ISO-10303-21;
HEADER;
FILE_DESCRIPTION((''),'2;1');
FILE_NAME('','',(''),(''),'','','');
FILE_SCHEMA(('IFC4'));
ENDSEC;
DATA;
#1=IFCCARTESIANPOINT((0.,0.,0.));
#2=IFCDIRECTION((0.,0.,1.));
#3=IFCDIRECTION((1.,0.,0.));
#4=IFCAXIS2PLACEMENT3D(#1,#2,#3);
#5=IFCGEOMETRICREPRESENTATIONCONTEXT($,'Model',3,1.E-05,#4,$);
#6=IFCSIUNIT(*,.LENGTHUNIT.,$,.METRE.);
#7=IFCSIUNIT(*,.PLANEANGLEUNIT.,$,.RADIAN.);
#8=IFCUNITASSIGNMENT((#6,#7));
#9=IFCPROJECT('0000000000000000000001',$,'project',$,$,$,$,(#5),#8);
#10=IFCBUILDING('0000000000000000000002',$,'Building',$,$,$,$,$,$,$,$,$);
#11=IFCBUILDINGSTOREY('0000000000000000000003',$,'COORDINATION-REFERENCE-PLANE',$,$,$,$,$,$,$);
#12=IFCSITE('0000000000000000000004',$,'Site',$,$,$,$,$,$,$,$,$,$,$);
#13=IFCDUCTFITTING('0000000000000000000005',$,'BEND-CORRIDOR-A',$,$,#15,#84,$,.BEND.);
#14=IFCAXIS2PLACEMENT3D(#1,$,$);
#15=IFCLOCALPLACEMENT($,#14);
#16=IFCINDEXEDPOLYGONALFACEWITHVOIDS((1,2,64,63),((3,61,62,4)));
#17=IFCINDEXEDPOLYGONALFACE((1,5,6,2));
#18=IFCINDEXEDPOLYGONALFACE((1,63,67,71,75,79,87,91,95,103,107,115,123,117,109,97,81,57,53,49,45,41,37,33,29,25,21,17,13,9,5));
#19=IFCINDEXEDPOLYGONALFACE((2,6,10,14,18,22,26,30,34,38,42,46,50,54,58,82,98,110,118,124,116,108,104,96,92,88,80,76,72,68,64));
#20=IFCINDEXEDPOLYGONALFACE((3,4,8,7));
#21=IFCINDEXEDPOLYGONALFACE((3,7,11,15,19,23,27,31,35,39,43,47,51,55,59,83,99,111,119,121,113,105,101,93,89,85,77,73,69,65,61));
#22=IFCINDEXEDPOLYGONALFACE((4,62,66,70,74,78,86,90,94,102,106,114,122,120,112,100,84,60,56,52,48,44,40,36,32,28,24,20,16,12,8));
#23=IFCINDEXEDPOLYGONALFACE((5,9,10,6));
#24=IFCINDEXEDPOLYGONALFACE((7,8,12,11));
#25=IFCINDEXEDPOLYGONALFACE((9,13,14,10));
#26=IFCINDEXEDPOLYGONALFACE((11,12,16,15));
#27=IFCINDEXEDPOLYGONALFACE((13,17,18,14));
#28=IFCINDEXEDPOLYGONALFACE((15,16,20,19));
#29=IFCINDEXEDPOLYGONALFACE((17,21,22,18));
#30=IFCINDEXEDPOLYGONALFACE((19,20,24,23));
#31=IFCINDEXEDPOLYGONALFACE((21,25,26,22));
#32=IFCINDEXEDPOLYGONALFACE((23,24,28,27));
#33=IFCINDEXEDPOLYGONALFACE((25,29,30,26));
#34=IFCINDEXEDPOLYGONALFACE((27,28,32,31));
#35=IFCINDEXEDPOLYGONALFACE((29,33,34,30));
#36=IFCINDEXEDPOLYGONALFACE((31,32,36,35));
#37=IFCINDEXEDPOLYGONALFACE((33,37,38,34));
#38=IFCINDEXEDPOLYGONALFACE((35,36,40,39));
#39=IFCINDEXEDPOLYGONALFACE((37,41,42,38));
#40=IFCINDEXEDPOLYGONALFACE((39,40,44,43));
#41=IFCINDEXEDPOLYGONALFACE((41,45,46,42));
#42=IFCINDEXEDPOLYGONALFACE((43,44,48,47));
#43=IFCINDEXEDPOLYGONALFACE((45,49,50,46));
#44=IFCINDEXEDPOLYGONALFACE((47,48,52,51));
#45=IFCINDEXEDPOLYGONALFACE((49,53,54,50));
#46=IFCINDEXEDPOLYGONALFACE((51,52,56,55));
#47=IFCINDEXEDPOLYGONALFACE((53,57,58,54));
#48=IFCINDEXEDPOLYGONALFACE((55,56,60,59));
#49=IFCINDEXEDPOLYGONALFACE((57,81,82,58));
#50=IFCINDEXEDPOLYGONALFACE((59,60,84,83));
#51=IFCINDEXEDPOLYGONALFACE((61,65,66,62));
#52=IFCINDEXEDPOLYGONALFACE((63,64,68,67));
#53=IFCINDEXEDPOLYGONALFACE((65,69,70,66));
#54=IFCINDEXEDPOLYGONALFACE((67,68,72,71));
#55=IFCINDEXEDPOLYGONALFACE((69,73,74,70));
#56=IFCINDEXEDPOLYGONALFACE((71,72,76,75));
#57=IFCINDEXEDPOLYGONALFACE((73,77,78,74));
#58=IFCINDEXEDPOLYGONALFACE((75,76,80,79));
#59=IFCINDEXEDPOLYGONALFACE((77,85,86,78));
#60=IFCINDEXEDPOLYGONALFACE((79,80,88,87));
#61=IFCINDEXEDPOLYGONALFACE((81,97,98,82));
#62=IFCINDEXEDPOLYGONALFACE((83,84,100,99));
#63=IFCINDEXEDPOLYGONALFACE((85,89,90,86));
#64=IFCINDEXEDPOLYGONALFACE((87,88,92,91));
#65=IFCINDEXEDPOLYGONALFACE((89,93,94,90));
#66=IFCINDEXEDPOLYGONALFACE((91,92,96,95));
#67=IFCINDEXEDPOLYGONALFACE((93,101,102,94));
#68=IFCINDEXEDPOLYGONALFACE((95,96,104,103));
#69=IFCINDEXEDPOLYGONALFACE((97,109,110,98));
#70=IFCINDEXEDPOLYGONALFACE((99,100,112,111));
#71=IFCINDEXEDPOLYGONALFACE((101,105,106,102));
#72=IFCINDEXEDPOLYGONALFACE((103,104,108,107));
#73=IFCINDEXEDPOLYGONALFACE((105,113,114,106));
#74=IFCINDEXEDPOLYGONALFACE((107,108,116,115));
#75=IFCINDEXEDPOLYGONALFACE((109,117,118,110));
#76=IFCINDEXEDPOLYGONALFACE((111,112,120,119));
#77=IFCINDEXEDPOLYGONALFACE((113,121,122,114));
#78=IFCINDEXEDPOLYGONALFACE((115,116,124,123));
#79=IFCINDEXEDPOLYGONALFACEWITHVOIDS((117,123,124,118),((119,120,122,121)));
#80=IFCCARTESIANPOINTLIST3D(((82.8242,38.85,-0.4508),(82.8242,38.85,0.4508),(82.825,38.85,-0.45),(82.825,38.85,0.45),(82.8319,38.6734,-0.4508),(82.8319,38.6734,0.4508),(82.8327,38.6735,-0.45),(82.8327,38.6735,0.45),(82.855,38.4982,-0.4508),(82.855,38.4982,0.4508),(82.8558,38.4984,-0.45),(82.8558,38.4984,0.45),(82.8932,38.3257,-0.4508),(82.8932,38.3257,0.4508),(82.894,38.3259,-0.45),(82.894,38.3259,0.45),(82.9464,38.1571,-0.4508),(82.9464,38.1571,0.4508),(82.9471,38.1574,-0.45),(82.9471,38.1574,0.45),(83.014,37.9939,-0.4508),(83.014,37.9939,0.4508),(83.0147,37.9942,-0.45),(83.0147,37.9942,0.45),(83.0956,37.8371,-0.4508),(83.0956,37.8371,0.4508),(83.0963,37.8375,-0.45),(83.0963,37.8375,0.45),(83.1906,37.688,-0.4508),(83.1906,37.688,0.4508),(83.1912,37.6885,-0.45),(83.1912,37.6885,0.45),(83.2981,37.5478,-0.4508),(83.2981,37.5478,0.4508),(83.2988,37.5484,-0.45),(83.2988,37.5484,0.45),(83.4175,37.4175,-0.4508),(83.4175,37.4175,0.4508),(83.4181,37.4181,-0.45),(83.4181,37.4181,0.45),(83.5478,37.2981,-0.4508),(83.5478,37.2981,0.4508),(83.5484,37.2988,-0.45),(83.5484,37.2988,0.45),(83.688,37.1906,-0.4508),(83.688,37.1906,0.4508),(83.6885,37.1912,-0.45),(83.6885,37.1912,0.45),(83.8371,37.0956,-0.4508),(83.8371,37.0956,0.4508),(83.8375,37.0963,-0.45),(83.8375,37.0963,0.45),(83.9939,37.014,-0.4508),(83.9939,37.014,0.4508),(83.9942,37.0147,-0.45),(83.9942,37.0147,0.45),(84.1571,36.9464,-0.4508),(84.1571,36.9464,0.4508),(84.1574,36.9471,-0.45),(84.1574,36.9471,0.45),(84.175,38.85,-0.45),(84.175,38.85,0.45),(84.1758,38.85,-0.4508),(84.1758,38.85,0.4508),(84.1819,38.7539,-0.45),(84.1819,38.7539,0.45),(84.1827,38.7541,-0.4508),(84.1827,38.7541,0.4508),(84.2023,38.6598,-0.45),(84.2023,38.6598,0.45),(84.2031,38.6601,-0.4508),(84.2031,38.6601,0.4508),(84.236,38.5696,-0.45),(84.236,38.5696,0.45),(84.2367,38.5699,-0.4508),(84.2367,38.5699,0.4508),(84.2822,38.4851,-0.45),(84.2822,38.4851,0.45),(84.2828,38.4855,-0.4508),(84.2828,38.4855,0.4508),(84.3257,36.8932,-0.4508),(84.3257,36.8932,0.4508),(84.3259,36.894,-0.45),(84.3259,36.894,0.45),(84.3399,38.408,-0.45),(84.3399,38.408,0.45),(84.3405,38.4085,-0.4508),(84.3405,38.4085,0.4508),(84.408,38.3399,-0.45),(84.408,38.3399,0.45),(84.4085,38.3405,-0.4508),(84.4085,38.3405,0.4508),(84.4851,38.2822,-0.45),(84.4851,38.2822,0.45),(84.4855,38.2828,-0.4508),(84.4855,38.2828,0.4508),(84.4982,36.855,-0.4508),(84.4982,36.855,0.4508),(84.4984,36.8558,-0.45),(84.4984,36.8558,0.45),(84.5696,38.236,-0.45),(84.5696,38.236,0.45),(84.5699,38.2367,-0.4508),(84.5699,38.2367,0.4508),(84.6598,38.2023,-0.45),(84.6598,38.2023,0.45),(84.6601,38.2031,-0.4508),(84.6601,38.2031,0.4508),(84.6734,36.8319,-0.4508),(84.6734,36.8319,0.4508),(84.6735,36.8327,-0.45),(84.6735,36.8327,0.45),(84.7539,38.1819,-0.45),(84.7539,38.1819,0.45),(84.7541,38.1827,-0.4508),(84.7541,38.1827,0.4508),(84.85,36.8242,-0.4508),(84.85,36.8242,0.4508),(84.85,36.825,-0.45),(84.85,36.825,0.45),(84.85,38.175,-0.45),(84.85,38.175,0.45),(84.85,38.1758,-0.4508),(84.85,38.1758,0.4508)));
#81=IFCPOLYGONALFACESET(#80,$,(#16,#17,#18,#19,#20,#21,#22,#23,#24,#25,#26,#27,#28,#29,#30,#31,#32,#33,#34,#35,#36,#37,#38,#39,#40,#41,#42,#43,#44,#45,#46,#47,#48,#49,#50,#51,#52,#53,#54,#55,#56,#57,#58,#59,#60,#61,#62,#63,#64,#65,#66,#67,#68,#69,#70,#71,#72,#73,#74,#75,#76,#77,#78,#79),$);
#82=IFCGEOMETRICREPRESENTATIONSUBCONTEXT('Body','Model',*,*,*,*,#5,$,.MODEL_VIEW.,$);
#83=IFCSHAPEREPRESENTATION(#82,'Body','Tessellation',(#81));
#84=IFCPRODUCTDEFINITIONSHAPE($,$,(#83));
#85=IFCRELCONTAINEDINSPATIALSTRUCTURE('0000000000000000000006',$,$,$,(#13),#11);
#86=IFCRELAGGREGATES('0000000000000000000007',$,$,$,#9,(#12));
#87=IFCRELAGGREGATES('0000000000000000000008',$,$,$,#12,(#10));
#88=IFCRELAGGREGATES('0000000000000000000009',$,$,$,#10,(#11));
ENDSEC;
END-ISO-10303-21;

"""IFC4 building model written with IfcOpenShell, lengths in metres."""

from ifc_helpers import new_model, entity, si_unit, frame, origin_with_axes, place, context, subcontext, project, spatial, element, save


model = new_model("IFC4")

# Units and contexts
model_context = context("Model", 3, precision=1e-05, world=origin_with_axes())
body_context = subcontext(model_context, "Body", "Model", "MODEL_VIEW")
ifc_project = project(units=[si_unit("LENGTHUNIT", "METRE"), si_unit("PLANEANGLEUNIT", "RADIAN")], contexts=[model_context])

# Site, building, storey
site = spatial("IfcSite", under=ifc_project, Name="Site")
building = spatial("IfcBuilding", under=site, Name="Building")
storey = spatial("IfcBuildingStorey", under=building, Name="COORDINATION-REFERENCE-PLANE")

# Duct fitting
duct_fitting_1_placement = place(None, frame((84.85, 38.85, 0.0), z_axis=(0.0, 0.0, 1.0), x_axis=(-1.0, 0.0, 0.0)))
cartesian_point_1 = entity("IfcCartesianPoint", [0.0, 0.0, 0.0])
element("IfcDuctFitting", 1, at=duct_fitting_1_placement, inside=storey, Name="BEND-CORRIDOR-A", PredefinedType="BEND", context=body_context, shape_type="SweptSolid", body=[
    entity("IfcRevolvedAreaSolid", entity("IfcRectangleHollowProfileDef", "AREA", None, entity("IfcAxis2Placement2D", entity("IfcCartesianPoint", [1.35, 0.0])), 1.3516, 0.9016, 0.0008), entity("IfcAxis2Placement3D", cartesian_point_1, entity("IfcDirection", [0.0, -1.0, 0.0]), entity("IfcDirection", [1.0, 0.0, 0.0])), entity("IfcAxis1Placement", cartesian_point_1, entity("IfcDirection", [0.0, 1.0, 0.0])), 1.570796),
])

save(model, "model.ifc")
